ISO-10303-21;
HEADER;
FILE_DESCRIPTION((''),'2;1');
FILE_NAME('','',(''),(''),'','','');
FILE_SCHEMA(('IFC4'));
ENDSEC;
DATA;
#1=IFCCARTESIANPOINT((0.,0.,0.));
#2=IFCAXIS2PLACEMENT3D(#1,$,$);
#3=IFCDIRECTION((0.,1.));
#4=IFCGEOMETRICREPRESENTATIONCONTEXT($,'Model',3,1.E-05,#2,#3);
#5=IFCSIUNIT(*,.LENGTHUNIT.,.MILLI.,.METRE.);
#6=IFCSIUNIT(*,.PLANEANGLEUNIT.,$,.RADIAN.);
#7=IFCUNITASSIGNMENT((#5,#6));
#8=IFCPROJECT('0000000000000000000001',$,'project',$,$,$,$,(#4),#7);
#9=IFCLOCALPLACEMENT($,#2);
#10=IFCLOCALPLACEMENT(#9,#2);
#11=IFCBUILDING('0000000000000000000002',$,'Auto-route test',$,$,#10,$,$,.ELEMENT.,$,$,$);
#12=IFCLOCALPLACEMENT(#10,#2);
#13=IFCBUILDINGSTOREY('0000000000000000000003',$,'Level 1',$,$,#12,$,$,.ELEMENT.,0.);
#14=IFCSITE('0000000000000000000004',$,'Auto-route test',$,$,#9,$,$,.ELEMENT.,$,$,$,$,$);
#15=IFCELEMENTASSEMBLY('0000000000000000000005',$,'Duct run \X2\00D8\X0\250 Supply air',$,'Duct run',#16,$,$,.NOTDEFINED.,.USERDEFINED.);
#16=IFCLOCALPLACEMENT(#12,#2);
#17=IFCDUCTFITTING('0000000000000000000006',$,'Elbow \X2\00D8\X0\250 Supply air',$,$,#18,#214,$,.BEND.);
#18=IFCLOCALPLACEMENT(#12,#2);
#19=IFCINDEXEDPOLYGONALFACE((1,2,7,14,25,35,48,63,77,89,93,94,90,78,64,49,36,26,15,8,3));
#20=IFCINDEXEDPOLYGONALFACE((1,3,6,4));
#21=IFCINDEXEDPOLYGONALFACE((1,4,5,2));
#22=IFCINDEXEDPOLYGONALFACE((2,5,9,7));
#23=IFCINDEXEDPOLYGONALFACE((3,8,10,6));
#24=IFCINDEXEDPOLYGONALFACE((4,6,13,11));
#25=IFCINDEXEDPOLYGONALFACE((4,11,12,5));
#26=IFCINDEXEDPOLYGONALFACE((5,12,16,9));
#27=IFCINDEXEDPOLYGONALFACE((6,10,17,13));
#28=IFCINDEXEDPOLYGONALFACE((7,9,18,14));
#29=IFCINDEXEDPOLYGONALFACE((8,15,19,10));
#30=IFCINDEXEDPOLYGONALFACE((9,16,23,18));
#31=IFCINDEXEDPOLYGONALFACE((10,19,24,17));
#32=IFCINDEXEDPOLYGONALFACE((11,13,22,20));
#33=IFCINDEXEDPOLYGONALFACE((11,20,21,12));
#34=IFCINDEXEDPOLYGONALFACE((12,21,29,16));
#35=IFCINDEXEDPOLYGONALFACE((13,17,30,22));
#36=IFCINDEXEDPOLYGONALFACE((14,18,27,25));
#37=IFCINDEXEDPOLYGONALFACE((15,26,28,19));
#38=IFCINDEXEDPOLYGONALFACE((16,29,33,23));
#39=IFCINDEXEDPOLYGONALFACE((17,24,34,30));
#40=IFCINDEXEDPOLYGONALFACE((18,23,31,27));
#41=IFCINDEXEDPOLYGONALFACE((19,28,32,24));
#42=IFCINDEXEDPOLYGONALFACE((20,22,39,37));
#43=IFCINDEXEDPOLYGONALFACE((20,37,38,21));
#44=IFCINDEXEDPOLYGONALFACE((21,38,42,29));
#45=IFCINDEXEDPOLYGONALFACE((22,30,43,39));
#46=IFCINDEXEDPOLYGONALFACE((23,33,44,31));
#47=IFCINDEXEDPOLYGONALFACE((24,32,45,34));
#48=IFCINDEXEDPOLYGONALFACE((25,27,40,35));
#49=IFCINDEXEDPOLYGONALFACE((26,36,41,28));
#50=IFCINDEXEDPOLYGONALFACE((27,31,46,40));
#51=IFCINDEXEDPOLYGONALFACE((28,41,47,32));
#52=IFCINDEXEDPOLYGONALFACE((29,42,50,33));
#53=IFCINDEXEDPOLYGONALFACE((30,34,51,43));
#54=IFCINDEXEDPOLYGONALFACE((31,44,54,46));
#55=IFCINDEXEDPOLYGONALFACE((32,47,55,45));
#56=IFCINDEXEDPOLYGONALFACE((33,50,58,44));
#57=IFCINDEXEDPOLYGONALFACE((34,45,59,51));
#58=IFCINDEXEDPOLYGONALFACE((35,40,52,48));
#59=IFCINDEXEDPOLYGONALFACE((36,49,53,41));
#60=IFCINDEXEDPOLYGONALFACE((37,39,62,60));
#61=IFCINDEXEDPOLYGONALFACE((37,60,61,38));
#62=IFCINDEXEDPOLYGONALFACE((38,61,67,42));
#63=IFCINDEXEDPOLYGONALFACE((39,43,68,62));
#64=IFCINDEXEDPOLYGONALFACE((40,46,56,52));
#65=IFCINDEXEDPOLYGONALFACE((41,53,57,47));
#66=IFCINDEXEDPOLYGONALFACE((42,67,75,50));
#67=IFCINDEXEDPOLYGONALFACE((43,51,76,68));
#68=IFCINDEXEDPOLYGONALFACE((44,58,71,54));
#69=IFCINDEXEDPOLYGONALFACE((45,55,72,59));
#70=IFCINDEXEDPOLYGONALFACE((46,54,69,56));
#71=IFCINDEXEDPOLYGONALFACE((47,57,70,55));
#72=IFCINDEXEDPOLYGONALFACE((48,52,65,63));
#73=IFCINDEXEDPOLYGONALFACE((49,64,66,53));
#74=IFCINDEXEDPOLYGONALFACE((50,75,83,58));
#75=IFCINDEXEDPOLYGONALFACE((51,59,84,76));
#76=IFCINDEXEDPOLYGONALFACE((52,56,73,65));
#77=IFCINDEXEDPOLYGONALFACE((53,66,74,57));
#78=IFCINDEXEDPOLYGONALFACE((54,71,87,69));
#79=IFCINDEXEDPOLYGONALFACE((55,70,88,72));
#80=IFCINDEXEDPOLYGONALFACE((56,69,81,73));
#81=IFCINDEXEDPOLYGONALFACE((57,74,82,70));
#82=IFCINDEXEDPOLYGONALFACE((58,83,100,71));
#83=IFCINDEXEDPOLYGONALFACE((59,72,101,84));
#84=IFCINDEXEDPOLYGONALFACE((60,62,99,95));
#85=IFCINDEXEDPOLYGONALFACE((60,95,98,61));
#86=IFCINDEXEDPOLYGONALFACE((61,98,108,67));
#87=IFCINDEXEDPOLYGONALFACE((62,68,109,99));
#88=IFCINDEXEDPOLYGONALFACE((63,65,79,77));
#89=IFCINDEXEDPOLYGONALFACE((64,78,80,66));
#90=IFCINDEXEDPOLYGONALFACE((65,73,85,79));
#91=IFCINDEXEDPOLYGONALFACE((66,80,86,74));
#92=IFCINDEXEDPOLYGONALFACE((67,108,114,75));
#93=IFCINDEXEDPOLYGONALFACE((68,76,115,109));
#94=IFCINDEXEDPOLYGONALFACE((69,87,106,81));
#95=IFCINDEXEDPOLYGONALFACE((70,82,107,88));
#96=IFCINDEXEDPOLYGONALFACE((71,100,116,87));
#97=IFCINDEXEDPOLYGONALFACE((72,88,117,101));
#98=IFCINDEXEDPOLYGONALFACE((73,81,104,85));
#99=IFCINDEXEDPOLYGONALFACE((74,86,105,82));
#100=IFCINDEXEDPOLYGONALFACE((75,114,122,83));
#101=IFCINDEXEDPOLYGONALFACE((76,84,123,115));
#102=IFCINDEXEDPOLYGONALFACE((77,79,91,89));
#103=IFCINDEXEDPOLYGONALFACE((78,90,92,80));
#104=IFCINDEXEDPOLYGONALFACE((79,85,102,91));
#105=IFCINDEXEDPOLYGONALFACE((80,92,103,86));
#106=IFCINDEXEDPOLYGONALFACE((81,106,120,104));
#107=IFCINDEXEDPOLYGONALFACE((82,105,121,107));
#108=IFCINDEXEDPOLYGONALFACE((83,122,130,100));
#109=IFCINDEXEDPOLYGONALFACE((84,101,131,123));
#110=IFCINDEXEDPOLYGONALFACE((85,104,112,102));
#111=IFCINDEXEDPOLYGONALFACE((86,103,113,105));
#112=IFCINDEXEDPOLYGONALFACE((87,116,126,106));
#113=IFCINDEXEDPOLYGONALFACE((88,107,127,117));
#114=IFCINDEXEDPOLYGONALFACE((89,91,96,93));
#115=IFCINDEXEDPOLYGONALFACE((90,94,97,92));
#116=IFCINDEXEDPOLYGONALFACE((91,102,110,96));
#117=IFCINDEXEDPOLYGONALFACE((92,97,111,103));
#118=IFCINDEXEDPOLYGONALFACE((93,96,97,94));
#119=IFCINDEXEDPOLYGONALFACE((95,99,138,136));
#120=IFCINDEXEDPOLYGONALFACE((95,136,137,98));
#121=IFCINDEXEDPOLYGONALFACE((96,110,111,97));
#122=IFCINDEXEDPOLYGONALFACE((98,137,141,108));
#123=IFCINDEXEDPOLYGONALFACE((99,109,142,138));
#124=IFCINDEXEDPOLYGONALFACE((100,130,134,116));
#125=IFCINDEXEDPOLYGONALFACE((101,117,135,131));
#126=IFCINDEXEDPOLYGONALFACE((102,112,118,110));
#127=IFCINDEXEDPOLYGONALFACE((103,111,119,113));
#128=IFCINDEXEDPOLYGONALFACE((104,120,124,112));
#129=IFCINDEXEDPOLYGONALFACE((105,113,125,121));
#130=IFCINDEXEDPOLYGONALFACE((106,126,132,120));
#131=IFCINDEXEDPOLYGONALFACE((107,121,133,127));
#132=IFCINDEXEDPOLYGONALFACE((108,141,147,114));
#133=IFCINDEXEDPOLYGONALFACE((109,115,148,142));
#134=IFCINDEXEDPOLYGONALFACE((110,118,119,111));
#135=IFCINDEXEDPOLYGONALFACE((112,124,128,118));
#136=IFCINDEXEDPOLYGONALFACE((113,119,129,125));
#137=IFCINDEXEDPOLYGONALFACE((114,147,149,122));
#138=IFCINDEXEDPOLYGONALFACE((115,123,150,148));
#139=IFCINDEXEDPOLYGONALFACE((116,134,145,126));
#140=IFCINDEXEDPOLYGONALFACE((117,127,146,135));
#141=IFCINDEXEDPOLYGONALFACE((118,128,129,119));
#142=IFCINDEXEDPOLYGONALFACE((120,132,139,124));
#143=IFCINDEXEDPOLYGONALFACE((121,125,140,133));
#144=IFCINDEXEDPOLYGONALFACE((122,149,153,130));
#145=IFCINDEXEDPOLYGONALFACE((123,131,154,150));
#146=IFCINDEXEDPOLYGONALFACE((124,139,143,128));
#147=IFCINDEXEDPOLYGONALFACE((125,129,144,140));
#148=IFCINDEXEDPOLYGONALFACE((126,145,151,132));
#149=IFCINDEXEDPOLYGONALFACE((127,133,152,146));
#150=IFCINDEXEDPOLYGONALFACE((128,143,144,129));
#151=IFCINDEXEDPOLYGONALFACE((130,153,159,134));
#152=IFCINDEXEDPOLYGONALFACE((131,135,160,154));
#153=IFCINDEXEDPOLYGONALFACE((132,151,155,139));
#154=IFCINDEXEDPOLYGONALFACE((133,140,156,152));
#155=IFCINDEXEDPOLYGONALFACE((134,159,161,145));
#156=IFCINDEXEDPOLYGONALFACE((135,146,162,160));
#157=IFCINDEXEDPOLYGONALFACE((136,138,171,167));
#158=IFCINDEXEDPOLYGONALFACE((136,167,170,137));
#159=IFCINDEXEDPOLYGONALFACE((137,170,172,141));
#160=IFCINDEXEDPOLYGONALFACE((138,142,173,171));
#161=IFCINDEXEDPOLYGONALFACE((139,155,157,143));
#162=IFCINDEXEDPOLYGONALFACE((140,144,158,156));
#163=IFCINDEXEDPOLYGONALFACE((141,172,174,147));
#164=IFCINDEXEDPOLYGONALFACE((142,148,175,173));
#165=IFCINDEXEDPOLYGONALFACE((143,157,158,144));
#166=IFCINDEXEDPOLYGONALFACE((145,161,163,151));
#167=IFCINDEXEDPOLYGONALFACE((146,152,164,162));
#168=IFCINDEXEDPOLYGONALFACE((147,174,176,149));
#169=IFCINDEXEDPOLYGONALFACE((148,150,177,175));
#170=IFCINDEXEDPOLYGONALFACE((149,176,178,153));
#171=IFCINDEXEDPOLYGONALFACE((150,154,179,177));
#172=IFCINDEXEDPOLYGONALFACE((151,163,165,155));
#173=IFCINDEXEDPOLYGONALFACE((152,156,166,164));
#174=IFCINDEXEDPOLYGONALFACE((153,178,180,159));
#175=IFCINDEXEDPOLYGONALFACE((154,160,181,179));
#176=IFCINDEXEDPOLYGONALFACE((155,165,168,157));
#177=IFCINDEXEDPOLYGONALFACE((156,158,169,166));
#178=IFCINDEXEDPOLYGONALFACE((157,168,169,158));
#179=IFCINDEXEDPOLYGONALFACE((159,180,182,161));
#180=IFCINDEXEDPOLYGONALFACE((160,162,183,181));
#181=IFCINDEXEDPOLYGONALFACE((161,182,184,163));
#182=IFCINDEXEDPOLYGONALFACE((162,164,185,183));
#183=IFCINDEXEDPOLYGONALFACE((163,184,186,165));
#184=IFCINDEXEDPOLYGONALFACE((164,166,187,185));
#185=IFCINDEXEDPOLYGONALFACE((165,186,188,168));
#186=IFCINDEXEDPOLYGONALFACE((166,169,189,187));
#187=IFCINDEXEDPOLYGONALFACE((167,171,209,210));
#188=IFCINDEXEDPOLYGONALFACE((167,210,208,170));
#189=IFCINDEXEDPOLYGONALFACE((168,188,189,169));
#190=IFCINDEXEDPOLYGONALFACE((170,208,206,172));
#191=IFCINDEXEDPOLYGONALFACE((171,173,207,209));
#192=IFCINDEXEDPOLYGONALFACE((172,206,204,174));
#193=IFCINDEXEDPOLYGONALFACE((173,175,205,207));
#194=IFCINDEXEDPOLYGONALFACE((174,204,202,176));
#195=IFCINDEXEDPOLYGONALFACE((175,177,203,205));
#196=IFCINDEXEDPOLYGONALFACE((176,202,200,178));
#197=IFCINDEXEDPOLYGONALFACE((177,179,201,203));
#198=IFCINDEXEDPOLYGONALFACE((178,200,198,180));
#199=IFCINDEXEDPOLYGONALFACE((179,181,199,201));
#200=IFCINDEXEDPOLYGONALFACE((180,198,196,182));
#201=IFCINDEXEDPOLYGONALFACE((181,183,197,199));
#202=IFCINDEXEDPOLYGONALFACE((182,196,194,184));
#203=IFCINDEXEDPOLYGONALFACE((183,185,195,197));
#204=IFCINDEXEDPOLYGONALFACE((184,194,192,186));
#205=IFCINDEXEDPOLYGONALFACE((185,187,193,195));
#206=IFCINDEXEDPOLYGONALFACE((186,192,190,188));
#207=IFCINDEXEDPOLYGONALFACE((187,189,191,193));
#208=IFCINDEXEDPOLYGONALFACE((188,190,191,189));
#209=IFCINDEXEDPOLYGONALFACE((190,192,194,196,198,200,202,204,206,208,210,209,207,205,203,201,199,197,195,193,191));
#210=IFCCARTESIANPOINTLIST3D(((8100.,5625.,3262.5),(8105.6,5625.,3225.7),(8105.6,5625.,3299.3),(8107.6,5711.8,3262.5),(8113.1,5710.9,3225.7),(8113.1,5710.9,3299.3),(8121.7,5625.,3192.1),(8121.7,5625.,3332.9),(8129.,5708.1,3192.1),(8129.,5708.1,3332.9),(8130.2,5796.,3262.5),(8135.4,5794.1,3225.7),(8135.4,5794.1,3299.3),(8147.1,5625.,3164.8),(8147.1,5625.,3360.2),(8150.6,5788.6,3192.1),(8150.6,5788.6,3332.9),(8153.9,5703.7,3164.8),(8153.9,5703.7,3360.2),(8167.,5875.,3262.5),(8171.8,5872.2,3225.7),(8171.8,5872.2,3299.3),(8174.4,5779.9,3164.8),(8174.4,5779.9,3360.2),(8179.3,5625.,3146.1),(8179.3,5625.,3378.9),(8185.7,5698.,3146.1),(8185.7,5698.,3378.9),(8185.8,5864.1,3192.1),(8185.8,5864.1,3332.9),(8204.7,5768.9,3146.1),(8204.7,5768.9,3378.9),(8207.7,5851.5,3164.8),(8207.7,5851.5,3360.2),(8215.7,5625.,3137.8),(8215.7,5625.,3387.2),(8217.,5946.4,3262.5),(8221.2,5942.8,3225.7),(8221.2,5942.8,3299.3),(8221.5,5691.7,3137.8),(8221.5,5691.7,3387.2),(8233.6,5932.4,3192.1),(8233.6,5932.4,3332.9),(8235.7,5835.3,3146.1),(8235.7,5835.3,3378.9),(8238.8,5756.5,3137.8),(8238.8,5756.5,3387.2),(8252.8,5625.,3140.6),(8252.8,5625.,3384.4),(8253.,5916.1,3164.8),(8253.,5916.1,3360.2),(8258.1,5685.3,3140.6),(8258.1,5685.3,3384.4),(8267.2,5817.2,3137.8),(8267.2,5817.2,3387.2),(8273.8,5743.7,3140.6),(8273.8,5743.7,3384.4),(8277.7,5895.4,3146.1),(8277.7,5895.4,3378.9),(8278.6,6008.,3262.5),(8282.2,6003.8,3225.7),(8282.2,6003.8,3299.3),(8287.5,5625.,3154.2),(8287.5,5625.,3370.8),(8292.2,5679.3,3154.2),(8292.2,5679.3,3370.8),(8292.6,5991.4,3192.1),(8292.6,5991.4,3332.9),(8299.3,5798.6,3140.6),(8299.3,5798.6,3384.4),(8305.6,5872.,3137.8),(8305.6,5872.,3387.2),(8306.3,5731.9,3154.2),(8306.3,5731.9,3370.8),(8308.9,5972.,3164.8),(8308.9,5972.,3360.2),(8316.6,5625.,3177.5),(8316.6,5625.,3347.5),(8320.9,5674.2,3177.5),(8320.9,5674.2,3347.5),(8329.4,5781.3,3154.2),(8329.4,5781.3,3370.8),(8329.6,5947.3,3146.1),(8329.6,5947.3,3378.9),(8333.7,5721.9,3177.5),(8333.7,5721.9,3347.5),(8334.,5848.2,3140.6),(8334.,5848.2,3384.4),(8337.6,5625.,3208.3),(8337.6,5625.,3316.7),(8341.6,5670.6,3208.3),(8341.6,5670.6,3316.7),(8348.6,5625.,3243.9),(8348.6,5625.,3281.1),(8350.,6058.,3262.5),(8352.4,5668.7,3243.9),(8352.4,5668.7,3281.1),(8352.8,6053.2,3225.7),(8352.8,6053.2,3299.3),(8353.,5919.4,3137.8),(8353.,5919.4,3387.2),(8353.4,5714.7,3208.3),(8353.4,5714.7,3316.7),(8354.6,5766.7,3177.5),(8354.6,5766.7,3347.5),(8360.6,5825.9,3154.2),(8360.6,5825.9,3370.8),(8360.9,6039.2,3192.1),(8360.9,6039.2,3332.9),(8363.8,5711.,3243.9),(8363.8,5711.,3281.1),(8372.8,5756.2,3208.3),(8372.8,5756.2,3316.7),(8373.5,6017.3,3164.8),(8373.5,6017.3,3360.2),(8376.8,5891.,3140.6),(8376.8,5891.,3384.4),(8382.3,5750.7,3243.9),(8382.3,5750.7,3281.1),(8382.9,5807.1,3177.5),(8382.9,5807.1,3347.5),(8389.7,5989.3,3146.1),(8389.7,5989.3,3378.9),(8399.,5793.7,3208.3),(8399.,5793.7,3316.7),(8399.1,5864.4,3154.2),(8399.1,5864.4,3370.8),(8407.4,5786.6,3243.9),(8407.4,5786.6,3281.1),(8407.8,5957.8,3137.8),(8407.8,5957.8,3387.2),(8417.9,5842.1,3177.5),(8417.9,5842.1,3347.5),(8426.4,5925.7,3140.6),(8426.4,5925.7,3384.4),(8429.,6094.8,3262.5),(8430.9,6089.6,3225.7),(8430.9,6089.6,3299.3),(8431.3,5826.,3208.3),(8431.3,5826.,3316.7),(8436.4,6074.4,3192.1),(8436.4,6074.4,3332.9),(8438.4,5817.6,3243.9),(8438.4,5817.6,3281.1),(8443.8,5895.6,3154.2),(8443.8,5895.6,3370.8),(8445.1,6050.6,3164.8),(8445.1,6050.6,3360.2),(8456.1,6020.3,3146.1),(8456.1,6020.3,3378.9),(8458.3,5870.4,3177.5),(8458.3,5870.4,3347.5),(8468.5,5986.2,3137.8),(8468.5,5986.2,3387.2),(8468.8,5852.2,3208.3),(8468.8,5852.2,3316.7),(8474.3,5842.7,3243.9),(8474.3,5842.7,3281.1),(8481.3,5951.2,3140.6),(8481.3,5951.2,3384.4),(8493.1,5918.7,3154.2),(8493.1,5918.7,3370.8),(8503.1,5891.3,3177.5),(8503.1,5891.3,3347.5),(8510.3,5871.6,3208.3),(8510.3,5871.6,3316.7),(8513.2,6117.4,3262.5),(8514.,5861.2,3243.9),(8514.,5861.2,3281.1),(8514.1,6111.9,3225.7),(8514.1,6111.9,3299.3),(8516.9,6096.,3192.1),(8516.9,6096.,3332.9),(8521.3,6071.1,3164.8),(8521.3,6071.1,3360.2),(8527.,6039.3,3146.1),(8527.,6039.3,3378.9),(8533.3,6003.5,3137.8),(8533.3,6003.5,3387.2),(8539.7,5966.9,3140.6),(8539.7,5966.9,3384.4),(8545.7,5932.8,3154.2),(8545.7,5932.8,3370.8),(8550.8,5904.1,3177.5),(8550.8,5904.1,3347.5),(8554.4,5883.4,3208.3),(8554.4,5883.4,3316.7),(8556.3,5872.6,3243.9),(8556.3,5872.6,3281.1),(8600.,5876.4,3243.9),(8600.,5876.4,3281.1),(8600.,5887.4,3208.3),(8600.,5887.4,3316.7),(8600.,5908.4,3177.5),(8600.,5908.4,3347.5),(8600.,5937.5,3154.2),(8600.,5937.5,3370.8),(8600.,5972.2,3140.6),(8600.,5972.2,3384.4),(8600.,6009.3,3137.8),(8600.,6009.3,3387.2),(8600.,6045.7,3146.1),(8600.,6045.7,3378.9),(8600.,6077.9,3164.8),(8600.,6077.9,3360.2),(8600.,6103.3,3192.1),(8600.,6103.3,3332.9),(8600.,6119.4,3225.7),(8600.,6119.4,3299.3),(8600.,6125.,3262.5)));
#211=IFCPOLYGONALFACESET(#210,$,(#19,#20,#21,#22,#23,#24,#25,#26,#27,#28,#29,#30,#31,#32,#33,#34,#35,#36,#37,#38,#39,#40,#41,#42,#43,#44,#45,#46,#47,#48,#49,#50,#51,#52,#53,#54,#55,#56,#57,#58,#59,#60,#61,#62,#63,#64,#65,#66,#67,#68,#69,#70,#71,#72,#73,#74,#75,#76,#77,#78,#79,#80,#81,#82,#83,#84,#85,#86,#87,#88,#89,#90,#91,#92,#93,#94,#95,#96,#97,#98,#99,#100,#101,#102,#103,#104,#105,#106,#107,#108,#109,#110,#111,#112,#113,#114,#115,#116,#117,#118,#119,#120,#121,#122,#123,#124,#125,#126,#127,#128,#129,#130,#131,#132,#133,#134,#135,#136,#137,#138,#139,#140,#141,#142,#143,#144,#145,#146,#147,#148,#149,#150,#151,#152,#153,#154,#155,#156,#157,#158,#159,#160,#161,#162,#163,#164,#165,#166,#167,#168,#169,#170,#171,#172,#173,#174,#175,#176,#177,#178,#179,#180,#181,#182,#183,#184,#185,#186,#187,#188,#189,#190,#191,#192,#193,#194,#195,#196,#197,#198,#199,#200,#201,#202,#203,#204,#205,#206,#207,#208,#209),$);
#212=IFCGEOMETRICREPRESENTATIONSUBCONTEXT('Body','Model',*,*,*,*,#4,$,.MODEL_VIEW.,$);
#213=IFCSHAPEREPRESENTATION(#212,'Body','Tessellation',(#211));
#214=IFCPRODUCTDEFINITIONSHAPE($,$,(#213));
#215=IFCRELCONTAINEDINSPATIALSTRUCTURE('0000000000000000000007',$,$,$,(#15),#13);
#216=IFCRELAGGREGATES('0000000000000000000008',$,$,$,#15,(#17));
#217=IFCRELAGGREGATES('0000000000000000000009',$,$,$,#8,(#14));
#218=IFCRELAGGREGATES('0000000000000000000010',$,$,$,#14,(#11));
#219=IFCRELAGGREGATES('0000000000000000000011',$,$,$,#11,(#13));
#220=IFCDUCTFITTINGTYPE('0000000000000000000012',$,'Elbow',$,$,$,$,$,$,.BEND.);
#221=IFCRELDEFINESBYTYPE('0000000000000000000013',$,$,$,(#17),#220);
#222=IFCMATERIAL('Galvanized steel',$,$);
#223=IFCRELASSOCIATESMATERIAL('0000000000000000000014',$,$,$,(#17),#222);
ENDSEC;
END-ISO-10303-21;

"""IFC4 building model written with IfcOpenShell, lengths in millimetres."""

from ifc_helpers import new_model, entity, si_unit, direction, origin, origin_with_axes, place, context, subcontext, project, spatial, material, type_object, element, aggregate, save


model = new_model("IFC4")

# Units and contexts
model_context = context("Model", 3, precision=1e-05, world=origin(), true_north=direction((0.0, 1.0)))
body_context = subcontext(model_context, "Body", "Model", "MODEL_VIEW")
ifc_project = project(units=[si_unit("LENGTHUNIT", "METRE", prefix="MILLI"), si_unit("PLANEANGLEUNIT", "RADIAN")], contexts=[model_context])

# Site, building, storey
site_placement = place(None, origin())
site = spatial("IfcSite", under=ifc_project, at=site_placement, Name="Auto-route test", CompositionType="ELEMENT")
building_placement = place(site_placement, origin())
building = spatial("IfcBuilding", under=site, at=building_placement, Name="Auto-route test", CompositionType="ELEMENT")
storey_placement = place(building_placement, origin())
storey = spatial("IfcBuildingStorey", under=building, at=storey_placement, Name="Level 1", CompositionType="ELEMENT", Elevation=0.0)

# Shared definitions
ifc_material_1 = material(Name="Galvanized steel")

# Shared definitions
duct_fitting_type_1 = type_object("IfcDuctFittingType", Name="Elbow", PredefinedType="BEND")

# Element assembly, duct fitting
assembly_1_placement = place(storey_placement, origin_with_axes())
assembly_1 = element("IfcElementAssembly", 1, at=assembly_1_placement, inside=storey, Name="Duct run Ø250 Supply air", ObjectType="Duct run", AssemblyPlace="NOTDEFINED", PredefinedType="USERDEFINED")
duct_fitting_1_placement = place(storey_placement, origin_with_axes())
duct_fitting_1 = element("IfcDuctFitting", 2, at=duct_fitting_1_placement, type_object=duct_fitting_type_1, material=ifc_material_1, Name="Elbow Ø250 Supply air", PredefinedType="BEND", context=body_context, shape_type="SweptSolid", body=[
    entity("IfcRevolvedAreaSolid", entity("IfcCircleProfileDef", "AREA", None, entity("IfcAxis2Placement2D", entity("IfcCartesianPoint", [0.0, 0.0])), 125.0), entity("IfcAxis2Placement3D", entity("IfcCartesianPoint", [8225.0, 5625.0, 3262.5]), entity("IfcDirection", [0.0, 1.0, 0.0]), entity("IfcDirection", [-1.0, 0.0, 0.0])), entity("IfcAxis1Placement", entity("IfcCartesianPoint", [-375.0, 0.0, 0.0]), entity("IfcDirection", [0.0, -1.0, 0.0])), 1.570796),
])

aggregate(assembly_1, [duct_fitting_1])

save(model, "model.ifc")
